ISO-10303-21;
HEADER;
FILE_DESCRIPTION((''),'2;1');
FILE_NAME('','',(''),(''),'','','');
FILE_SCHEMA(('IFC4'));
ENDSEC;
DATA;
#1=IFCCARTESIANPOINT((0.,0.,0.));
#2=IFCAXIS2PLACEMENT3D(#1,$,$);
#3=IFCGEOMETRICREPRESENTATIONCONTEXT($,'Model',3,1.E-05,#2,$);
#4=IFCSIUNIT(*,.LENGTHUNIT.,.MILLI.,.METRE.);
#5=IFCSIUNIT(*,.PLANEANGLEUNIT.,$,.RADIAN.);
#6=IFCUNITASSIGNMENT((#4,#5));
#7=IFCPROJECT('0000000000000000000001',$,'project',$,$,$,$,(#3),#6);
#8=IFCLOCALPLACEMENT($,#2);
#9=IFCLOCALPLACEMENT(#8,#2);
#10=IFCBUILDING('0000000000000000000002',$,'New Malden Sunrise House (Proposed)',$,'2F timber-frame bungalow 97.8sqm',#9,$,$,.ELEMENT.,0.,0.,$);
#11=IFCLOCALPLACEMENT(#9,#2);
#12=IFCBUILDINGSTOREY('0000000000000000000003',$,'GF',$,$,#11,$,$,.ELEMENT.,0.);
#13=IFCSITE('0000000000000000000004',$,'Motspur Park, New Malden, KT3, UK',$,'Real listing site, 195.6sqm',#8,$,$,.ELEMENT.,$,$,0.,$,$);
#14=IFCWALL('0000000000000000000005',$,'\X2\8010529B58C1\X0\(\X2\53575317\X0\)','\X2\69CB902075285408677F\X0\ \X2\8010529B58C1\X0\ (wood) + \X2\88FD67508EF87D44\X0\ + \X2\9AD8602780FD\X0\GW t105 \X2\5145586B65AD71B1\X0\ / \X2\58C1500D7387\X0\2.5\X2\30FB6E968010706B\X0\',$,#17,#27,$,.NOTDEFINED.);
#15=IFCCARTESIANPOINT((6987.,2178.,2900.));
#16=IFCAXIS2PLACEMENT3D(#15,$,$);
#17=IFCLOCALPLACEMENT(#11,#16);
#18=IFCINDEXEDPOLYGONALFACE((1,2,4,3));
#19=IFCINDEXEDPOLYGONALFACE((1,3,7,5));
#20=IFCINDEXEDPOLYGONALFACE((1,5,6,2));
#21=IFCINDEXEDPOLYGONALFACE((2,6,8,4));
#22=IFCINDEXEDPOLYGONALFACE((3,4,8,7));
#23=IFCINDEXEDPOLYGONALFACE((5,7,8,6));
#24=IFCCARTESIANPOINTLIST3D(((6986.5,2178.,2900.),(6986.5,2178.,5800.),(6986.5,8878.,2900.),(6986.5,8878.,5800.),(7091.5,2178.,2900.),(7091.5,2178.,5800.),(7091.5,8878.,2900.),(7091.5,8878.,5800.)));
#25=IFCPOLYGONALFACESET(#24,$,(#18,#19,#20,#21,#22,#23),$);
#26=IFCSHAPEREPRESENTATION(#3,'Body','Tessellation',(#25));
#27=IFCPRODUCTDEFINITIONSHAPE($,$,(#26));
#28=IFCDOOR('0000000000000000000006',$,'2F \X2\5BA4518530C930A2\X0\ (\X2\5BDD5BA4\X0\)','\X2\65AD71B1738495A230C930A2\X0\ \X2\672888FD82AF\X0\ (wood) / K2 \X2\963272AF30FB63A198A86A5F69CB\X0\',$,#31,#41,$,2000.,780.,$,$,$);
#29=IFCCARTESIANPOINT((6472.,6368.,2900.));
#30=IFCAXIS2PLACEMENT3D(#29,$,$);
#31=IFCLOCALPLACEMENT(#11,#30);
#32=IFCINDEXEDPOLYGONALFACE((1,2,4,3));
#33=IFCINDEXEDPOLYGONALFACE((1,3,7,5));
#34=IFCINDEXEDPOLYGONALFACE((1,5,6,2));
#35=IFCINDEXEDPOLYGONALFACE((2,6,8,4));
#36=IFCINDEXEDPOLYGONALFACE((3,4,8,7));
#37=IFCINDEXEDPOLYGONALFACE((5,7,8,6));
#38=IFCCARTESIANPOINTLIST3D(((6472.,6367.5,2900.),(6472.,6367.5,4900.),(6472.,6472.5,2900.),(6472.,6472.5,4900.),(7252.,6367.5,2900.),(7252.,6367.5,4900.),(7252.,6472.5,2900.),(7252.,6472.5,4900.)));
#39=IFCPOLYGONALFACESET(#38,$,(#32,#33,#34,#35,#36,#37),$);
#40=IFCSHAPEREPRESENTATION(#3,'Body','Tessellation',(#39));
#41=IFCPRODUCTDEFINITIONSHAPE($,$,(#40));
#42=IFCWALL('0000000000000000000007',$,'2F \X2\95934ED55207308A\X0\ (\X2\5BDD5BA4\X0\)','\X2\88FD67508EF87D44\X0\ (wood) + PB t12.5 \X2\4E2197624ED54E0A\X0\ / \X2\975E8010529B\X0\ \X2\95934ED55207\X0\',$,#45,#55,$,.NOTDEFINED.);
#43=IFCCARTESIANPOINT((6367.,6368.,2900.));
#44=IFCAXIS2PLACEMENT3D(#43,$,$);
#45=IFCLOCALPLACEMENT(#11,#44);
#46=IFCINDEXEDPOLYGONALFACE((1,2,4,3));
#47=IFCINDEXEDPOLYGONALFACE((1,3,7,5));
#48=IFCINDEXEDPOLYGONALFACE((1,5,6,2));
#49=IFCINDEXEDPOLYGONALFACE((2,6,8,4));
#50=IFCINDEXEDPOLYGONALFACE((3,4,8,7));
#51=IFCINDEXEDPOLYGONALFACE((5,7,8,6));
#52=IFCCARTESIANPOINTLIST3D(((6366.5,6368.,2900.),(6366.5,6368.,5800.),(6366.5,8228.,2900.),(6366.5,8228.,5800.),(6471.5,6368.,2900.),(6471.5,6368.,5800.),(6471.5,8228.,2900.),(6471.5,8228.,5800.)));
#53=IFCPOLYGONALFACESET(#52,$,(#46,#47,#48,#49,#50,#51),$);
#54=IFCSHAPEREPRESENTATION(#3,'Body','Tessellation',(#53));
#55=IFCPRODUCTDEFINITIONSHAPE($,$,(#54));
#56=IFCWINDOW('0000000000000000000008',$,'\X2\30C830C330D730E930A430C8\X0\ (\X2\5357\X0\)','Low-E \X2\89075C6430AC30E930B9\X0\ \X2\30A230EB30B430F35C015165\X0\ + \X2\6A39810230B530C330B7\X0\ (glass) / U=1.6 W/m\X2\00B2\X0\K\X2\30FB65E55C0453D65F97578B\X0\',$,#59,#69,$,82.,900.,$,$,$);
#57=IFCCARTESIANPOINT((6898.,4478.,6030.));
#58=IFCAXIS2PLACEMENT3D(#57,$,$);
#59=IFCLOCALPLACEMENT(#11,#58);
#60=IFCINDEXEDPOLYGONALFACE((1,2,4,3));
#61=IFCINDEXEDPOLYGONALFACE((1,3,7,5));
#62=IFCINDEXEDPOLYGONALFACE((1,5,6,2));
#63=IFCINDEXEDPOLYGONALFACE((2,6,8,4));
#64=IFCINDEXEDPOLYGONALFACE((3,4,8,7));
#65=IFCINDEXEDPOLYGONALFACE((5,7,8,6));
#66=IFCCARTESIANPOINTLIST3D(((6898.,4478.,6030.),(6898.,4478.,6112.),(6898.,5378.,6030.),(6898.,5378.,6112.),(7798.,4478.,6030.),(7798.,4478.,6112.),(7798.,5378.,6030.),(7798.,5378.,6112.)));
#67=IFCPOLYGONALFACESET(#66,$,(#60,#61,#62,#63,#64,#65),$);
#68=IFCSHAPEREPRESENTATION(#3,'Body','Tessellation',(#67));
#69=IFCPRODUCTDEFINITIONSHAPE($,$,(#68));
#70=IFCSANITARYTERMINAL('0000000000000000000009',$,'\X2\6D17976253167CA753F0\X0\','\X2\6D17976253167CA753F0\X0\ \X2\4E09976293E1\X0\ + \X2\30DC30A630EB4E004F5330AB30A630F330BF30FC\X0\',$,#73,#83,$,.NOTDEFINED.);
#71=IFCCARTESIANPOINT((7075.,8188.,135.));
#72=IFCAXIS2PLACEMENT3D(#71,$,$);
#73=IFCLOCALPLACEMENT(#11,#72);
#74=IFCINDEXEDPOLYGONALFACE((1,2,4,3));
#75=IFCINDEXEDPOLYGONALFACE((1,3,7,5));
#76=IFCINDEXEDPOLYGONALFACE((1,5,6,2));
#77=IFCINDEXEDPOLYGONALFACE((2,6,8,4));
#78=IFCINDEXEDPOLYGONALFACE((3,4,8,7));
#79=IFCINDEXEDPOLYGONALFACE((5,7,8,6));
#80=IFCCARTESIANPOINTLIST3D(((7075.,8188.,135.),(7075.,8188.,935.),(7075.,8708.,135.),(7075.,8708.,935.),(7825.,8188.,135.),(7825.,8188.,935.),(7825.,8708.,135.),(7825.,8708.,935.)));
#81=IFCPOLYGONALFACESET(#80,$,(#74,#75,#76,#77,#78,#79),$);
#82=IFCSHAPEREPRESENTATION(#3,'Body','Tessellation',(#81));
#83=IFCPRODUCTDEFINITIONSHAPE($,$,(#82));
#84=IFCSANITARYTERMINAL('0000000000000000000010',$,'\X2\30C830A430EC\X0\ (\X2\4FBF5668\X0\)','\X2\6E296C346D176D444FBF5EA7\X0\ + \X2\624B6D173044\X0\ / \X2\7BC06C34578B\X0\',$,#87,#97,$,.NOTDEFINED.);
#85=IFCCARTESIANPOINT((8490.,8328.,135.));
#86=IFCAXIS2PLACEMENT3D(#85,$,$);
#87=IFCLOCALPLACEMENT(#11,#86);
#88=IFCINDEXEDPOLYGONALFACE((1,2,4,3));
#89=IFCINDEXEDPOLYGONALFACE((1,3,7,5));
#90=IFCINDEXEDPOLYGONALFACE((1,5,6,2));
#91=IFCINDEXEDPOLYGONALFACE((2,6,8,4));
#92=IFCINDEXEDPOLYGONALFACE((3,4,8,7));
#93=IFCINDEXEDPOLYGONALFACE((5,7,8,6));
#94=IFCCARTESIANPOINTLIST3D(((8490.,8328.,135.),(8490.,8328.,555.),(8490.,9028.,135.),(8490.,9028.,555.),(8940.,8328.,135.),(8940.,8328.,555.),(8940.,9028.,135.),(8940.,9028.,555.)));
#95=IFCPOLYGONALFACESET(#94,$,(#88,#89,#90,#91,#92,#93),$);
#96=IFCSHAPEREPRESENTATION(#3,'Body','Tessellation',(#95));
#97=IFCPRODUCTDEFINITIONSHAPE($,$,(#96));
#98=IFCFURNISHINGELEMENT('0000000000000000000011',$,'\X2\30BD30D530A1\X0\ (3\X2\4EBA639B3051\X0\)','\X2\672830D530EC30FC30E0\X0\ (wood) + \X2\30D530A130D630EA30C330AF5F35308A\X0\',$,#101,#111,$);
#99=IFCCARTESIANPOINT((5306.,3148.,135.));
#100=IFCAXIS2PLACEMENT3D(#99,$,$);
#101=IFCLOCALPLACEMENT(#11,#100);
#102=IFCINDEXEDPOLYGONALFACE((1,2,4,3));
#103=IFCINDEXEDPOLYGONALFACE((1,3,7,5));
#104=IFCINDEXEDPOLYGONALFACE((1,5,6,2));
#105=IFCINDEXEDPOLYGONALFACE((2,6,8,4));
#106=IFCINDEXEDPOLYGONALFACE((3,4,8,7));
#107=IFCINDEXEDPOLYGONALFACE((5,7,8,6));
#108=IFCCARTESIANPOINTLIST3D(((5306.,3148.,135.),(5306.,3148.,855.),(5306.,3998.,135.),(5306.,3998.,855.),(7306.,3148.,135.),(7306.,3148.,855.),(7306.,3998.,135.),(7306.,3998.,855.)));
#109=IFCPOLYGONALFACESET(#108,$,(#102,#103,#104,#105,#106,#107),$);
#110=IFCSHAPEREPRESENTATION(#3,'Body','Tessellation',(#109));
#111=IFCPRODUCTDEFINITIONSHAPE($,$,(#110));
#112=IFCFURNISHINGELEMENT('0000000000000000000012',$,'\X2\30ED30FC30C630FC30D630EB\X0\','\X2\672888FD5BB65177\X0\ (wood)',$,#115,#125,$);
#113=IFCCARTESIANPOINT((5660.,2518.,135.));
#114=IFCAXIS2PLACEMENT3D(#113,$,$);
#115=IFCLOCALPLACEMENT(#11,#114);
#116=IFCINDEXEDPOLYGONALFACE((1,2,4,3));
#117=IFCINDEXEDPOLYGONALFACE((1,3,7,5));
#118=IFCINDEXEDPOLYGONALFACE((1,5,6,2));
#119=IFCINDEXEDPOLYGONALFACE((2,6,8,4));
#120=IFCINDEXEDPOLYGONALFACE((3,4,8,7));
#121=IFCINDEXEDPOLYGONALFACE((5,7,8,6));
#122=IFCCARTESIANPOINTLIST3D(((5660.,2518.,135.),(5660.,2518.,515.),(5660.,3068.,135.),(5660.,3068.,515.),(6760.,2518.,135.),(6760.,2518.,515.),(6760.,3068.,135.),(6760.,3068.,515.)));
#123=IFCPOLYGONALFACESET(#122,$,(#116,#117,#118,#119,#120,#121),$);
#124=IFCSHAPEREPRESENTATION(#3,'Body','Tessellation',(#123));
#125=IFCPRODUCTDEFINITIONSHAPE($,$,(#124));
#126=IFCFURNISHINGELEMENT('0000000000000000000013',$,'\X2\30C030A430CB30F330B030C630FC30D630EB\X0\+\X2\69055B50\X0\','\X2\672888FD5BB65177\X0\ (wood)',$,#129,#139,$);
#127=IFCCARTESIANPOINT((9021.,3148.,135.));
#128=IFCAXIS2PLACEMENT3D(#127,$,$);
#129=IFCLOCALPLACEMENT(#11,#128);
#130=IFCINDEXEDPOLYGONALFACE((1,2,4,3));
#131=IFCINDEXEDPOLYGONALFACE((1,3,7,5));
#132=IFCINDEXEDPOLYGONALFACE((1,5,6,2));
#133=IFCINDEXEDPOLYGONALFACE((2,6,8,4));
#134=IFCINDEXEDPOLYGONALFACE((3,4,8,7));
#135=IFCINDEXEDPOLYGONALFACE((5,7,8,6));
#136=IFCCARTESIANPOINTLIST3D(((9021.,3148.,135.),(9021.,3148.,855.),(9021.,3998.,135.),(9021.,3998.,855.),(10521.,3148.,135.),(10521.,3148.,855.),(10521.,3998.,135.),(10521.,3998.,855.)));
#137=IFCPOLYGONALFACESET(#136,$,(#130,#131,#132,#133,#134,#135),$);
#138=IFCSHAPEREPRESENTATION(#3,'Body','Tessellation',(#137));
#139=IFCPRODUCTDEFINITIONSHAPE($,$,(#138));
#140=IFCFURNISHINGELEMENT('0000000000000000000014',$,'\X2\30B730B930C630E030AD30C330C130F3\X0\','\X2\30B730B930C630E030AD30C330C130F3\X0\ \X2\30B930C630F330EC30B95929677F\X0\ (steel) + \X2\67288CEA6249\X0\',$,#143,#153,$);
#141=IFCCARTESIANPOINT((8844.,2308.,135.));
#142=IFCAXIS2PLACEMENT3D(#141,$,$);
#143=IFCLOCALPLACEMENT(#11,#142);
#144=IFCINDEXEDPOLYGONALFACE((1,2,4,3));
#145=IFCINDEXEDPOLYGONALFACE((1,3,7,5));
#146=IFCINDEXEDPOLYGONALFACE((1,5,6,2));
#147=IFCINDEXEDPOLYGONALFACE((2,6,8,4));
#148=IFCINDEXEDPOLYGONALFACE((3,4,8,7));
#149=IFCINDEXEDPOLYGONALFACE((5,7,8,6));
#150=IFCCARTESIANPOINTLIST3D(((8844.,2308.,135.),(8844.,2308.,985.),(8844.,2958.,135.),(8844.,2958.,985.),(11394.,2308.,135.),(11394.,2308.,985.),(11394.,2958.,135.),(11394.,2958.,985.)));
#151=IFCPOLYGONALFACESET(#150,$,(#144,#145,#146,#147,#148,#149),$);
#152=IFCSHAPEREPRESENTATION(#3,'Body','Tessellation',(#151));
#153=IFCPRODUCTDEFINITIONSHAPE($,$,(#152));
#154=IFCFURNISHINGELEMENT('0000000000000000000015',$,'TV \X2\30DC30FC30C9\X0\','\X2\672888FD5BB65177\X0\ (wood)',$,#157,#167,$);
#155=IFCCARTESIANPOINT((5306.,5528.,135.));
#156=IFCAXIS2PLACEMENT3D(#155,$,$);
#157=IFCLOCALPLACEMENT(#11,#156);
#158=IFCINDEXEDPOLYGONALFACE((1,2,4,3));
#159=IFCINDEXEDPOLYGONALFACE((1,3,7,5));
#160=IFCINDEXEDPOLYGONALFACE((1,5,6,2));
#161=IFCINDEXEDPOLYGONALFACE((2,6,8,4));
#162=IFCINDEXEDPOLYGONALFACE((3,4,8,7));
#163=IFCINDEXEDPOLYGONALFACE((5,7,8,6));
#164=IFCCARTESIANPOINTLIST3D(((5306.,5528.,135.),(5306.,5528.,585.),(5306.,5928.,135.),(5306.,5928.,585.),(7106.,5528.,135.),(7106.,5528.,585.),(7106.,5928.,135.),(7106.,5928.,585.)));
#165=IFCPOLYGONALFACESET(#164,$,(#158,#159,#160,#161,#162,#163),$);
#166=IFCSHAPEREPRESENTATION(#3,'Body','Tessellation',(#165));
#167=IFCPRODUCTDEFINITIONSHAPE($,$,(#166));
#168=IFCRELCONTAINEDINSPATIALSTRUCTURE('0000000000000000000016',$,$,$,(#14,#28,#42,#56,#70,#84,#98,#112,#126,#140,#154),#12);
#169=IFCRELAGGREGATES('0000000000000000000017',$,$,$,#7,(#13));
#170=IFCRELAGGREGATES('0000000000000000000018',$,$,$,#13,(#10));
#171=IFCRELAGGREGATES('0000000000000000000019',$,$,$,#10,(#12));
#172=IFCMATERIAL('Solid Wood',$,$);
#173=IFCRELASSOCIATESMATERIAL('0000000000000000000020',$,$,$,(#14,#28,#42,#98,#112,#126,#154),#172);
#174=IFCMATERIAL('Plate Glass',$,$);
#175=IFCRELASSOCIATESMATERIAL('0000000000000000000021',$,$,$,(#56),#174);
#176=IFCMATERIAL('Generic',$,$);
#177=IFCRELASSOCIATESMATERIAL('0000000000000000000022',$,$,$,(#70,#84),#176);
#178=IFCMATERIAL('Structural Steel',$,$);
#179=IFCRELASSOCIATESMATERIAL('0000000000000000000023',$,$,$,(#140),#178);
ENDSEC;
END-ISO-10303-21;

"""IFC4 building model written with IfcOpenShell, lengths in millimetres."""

from ifc_helpers import new_model, si_unit, frame, frame_2d, origin, place, context, project, spatial, rectangle, extrude, material, element, fill, save


model = new_model("IFC4")

# Units and contexts
model_context = context("Model", 3, precision=1e-05, world=origin())
ifc_project = project(units=[si_unit("LENGTHUNIT", "METRE", prefix="MILLI"), si_unit("PLANEANGLEUNIT", "RADIAN")], contexts=[model_context])

# Site, building, storey
site_placement = place(None, origin())
site = spatial("IfcSite", under=ifc_project, at=site_placement, Name="Motspur Park, New Malden, KT3, UK", ObjectType="Real listing site, 195.6sqm", CompositionType="ELEMENT", RefElevation=0.0)
building_placement = place(site_placement, origin())
building = spatial("IfcBuilding", under=site, at=building_placement, Name="New Malden Sunrise House (Proposed)", ObjectType="2F timber-frame bungalow 97.8sqm", CompositionType="ELEMENT", ElevationOfRefHeight=0.0, ElevationOfTerrain=0.0)
storey_placement = place(building_placement, origin())
storey = spatial("IfcBuildingStorey", under=building, at=storey_placement, Name="GF", CompositionType="ELEMENT", Elevation=0.0)

# Shared definitions
ifc_material_1 = material(Name="Solid Wood")

# Wall, opening, door
wall_1_placement = place(storey_placement, frame((6987.0, 2178.0, 2900.0)))
wall_1 = element("IfcWall", 1, at=wall_1_placement, inside=storey, material=ifc_material_1, Name="耐力壁(南北)", Description="構造用合板 耐力壁 (wood) + 製材軸組 + 高性能GW t105 充填断熱 / 壁倍率2.5・準耐火", PredefinedType="NOTDEFINED", context=model_context, shape_type="SweptSolid", body=[
    extrude(rectangle(XDim=105.0, YDim=6700.0, at=frame_2d((52.0, 3350.0))), frame((6987.0, 2178.0, 2900.0)), (0.0, 0.0, 1.0), 2900.0),
])
opening_1_placement = place(storey_placement, frame((6472.0, 6368.0, 2900.0)))
opening_1 = element("IfcOpeningElement", 2, at=opening_1_placement, cuts=wall_1, PredefinedType="NOTDEFINED", context=model_context, shape_type="SweptSolid", body=[
    extrude(rectangle(XDim=780.0, YDim=105.0, at=frame_2d((390.0, 52.0))), frame((6472.0, 6368.0, 2900.0)), (0.0, 0.0, 1.0), 2000.0),
])
door_1_placement = place(storey_placement, frame((6472.0, 6368.0, 2900.0)))
door_1 = element("IfcDoor", 3, at=door_1_placement, inside=storey, material=ifc_material_1, Name="2F 室内ドア (寝室)", Description="断熱玄関ドア 木製芯 (wood) / K2 防犯・採風機構", OverallHeight=2000.0, OverallWidth=780.0, context=model_context, shape_type="SweptSolid", body=[
    extrude(rectangle(XDim=780.0, YDim=105.0, at=frame_2d((390.0, 52.0))), frame((6472.0, 6368.0, 2900.0)), (0.0, 0.0, 1.0), 2000.0),
])
fill(opening_1, door_1)

# Wall
wall_2_placement = place(storey_placement, frame((6367.0, 6368.0, 2900.0)))
element("IfcWall", 4, at=wall_2_placement, inside=storey, material=ifc_material_1, Name="2F 間仕切り (寝室)", Description="製材軸組 (wood) + PB t12.5 両面仕上 / 非耐力 間仕切", PredefinedType="NOTDEFINED", context=model_context, shape_type="SweptSolid", body=[
    extrude(rectangle(XDim=105.0, YDim=1860.0, at=frame_2d((52.0, 930.0))), frame((6367.0, 6368.0, 2900.0)), (0.0, 0.0, 1.0), 2900.0),
])

# Window
ifc_material_2 = material(Name="Plate Glass")
window_placement = place(storey_placement, frame((6898.0, 4478.0, 6030.0)))
element("IfcWindow", 5, at=window_placement, inside=storey, material=ifc_material_2, Name="トップライト (南)", Description="Low-E 複層ガラス アルゴン封入 + 樹脂サッシ (glass) / U=1.6 W/m²K・日射取得型", OverallHeight=82.0, OverallWidth=900.0, context=model_context, shape_type="SweptSolid", body=[
    extrude(rectangle(XDim=900.0, YDim=900.0, at=frame_2d((450.0, 450.0))), frame((6898.0, 4478.0, 6030.0)), (0.0, 0.0, 1.0), 82.0),
])

# Sanitary terminals
ifc_material_3 = material(Name="Generic")
sanitary_terminal_1_placement = place(storey_placement, frame((7075.0, 8188.0, 135.0)))
element("IfcSanitaryTerminal", 6, at=sanitary_terminal_1_placement, inside=storey, material=ifc_material_3, Name="洗面化粧台", Description="洗面化粧台 三面鏡 + ボウル一体カウンター", PredefinedType="NOTDEFINED", context=model_context, shape_type="SweptSolid", body=[
    extrude(rectangle(XDim=750.0, YDim=520.0, at=frame_2d((375.0, 260.0))), frame((7075.0, 8188.0, 135.0)), (0.0, 0.0, 1.0), 800.0),
])
sanitary_terminal_2_placement = place(storey_placement, frame((8490.0, 8328.0, 135.0)))
element("IfcSanitaryTerminal", 7, at=sanitary_terminal_2_placement, inside=storey, material=ifc_material_3, Name="トイレ (便器)", Description="温水洗浄便座 + 手洗い / 節水型", PredefinedType="NOTDEFINED", context=model_context, shape_type="SweptSolid", body=[
    extrude(rectangle(XDim=450.0, YDim=700.0, at=frame_2d((225.0, 350.0))), frame((8490.0, 8328.0, 135.0)), (0.0, 0.0, 1.0), 420.0),
])

# Furnishing elements
furnishing_1_placement = place(storey_placement, frame((5306.0, 3148.0, 135.0)))
element("IfcFurnishingElement", 8, at=furnishing_1_placement, inside=storey, material=ifc_material_1, Name="ソファ (3人掛け)", Description="木フレーム (wood) + ファブリック張り", context=model_context, shape_type="SweptSolid", body=[
    extrude(rectangle(XDim=2000.0, YDim=850.0, at=frame_2d((1000.0, 425.0))), frame((5306.0, 3148.0, 135.0)), (0.0, 0.0, 1.0), 720.0),
])
furnishing_2_placement = place(storey_placement, frame((5660.0, 2518.0, 135.0)))
element("IfcFurnishingElement", 9, at=furnishing_2_placement, inside=storey, material=ifc_material_1, Name="ローテーブル", Description="木製家具 (wood)", context=model_context, shape_type="SweptSolid", body=[
    extrude(rectangle(XDim=1100.0, YDim=550.0, at=frame_2d((550.0, 275.0))), frame((5660.0, 2518.0, 135.0)), (0.0, 0.0, 1.0), 380.0),
])
furnishing_3_placement = place(storey_placement, frame((9021.0, 3148.0, 135.0)))
element("IfcFurnishingElement", 10, at=furnishing_3_placement, inside=storey, material=ifc_material_1, Name="ダイニングテーブル+椅子", Description="木製家具 (wood)", context=model_context, shape_type="SweptSolid", body=[
    extrude(rectangle(XDim=1500.0, YDim=850.0, at=frame_2d((750.0, 425.0))), frame((9021.0, 3148.0, 135.0)), (0.0, 0.0, 1.0), 720.0),
])
ifc_material_4 = material(Name="Structural Steel")
furnishing_4_placement = place(storey_placement, frame((8844.0, 2308.0, 135.0)))
element("IfcFurnishingElement", 11, at=furnishing_4_placement, inside=storey, material=ifc_material_4, Name="システムキッチン", Description="システムキッチン ステンレス天板 (steel) + 木質扉", context=model_context, shape_type="SweptSolid", body=[
    extrude(rectangle(XDim=2550.0, YDim=650.0, at=frame_2d((1275.0, 325.0))), frame((8844.0, 2308.0, 135.0)), (0.0, 0.0, 1.0), 850.0),
])
furnishing_5_placement = place(storey_placement, frame((5306.0, 5528.0, 135.0)))
element("IfcFurnishingElement", 12, at=furnishing_5_placement, inside=storey, material=ifc_material_1, Name="TV ボード", Description="木製家具 (wood)", context=model_context, shape_type="SweptSolid", body=[
    extrude(rectangle(XDim=1800.0, YDim=400.0, at=frame_2d((900.0, 200.0))), frame((5306.0, 5528.0, 135.0)), (0.0, 0.0, 1.0), 450.0),
])

save(model, "model.ifc")
